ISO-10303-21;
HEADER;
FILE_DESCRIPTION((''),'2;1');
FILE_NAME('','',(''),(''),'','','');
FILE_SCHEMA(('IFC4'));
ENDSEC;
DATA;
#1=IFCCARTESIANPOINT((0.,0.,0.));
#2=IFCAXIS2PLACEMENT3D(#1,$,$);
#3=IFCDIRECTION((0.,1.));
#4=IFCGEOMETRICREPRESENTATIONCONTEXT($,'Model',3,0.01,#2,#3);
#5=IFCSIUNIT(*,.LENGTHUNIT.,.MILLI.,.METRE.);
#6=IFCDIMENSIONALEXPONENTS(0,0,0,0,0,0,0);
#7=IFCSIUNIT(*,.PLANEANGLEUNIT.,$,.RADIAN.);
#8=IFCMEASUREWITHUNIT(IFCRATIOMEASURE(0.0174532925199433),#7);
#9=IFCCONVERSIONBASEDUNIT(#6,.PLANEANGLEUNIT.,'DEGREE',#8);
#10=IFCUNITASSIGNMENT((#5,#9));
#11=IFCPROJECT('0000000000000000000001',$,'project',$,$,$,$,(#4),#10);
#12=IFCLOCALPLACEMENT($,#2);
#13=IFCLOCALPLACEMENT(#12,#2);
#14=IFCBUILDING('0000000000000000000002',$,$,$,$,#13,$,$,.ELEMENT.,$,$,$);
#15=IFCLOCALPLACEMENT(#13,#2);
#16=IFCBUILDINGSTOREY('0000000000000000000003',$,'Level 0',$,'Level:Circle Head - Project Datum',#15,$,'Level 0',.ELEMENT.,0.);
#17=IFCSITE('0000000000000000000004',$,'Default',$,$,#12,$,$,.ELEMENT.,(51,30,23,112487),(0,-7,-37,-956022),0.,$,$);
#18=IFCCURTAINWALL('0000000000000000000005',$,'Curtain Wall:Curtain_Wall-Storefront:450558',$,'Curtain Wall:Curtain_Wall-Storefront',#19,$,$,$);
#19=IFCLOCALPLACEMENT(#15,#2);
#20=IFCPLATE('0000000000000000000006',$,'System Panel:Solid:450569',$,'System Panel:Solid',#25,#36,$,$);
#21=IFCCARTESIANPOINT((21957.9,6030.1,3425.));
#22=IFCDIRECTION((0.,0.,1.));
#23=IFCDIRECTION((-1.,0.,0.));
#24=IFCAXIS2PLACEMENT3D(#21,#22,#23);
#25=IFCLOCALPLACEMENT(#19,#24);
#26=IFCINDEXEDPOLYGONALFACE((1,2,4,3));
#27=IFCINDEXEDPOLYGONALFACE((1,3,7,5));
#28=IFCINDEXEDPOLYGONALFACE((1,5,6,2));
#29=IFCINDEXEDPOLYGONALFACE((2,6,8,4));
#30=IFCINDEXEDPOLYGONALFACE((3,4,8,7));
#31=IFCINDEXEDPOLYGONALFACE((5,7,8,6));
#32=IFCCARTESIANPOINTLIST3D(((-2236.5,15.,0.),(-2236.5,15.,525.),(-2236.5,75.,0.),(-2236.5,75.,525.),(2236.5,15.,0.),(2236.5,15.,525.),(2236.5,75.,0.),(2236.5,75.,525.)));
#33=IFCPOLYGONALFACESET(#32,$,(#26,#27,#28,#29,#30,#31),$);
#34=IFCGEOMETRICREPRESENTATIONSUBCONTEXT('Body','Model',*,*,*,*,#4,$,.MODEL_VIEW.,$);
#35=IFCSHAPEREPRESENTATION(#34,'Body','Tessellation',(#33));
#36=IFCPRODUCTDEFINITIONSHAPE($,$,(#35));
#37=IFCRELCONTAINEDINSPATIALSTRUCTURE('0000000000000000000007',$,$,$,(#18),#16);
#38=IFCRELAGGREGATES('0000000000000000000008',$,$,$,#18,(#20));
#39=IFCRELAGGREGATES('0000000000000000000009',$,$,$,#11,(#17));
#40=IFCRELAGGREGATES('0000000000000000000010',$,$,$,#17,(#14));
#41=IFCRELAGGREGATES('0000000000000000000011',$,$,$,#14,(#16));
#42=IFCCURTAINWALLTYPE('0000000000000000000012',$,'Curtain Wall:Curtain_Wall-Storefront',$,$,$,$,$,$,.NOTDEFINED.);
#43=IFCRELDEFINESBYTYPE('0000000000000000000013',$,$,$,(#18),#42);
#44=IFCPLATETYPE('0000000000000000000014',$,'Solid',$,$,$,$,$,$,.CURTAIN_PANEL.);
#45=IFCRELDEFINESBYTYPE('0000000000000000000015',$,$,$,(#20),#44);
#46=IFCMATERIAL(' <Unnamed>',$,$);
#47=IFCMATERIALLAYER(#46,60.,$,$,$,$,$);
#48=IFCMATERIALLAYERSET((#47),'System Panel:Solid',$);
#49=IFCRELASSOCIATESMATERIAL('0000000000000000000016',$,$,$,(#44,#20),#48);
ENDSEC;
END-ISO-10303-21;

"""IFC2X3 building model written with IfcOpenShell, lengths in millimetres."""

from ifc_helpers import new_model, entity, si_unit, converted_unit, direction, frame, frame_2d, origin, place, context, subcontext, project, spatial, rectangle, extrude, source, transform, mapped, material, layer, layer_set, layer_usage, type_object, type_shapes, element, aggregate, save


model = new_model("IFC2X3")

# Units and contexts
model_context = context("Model", 3, precision=0.01, world=origin(), true_north=direction((0.0, 1.0)))
body_context = subcontext(model_context, "Body", "Model", "MODEL_VIEW")
ifc_project = project(units=[si_unit("LENGTHUNIT", "METRE", prefix="MILLI"), converted_unit("PLANEANGLEUNIT", "DEGREE", entity("IfcRatioMeasure", 0.0174532925199433), si_unit("PLANEANGLEUNIT", "RADIAN"), dimensions=[0, 0, 0, 0, 0, 0, 0])], contexts=[model_context])

# Site, building, storey
site_placement = place(None, origin())
site = spatial("IfcSite", under=ifc_project, at=site_placement, Name="Default", CompositionType="ELEMENT", RefLatitude=(51, 30, 23, 112487), RefLongitude=(0, -7, -37, -956022), RefElevation=0.0)
building_placement = place(site_placement, origin())
building = spatial("IfcBuilding", under=site, at=building_placement, CompositionType="ELEMENT")
storey_placement = place(building_placement, origin())
storey = spatial("IfcBuildingStorey", under=building, at=storey_placement, Name="Level 0", ObjectType="Level:Circle Head - Project Datum", LongName="Level 0", CompositionType="ELEMENT", Elevation=0.0)

# Curtain wall, plate
curtain_wall_type = type_object("IfcCurtainWallType", Name="Curtain Wall:Curtain_Wall-Storefront", PredefinedType="NOTDEFINED")
curtain_wall_placement = place(storey_placement, origin())
curtain_wall = element("IfcCurtainWall", 1, at=curtain_wall_placement, inside=storey, type_object=curtain_wall_type, Name="Curtain Wall:Curtain_Wall-Storefront:450558", ObjectType="Curtain Wall:Curtain_Wall-Storefront")
ifc_material_1 = material(Name=" <Unnamed>")
ifc_layer_1 = layer(ifc_material_1, 60.0)
ifc_layer_set_1 = layer_set([ifc_layer_1], Name="System Panel:Solid")
ifc_layer_usage_1 = layer_usage(ifc_layer_set_1, "AXIS3", "POSITIVE", 0.1)
plate_type_1 = type_object("IfcPlateType", Name="Solid", PredefinedType="CURTAIN_PANEL", material=ifc_layer_set_1)
shared_shape_1 = source(origin(), body_context, "Body", "SweptSolid", [
    extrude(rectangle(XDim=525.0, YDim=4473.0, at=frame_2d((0.0, -4.2), x_axis=(1.0, 0.0))), frame((4.3, 15.0, 262.5), z_axis=(0.0, 1.0, 0.0), x_axis=(0.0, 0.0, 1.0)), (0.0, 0.0, 1.0), 60.0),
])
type_shapes(plate_type_1, [shared_shape_1])
plate_1_placement = place(curtain_wall_placement, frame((21957.9, 6030.1, 3425.0), z_axis=(0.0, 0.0, 1.0), x_axis=(-1.0, 0.0, 0.0)))
plate_1 = element("IfcPlate", 2, at=plate_1_placement, type_object=plate_type_1, material=ifc_layer_usage_1, Name="System Panel:Solid:450569", ObjectType="System Panel:Solid", context=body_context, shape_type="MappedRepresentation", body=[
    mapped(shared_shape_1, transform((0.0, 0.0, 0.0), scale=1.0)),
])
aggregate(curtain_wall, [plate_1])

save(model, "model.ifc")
